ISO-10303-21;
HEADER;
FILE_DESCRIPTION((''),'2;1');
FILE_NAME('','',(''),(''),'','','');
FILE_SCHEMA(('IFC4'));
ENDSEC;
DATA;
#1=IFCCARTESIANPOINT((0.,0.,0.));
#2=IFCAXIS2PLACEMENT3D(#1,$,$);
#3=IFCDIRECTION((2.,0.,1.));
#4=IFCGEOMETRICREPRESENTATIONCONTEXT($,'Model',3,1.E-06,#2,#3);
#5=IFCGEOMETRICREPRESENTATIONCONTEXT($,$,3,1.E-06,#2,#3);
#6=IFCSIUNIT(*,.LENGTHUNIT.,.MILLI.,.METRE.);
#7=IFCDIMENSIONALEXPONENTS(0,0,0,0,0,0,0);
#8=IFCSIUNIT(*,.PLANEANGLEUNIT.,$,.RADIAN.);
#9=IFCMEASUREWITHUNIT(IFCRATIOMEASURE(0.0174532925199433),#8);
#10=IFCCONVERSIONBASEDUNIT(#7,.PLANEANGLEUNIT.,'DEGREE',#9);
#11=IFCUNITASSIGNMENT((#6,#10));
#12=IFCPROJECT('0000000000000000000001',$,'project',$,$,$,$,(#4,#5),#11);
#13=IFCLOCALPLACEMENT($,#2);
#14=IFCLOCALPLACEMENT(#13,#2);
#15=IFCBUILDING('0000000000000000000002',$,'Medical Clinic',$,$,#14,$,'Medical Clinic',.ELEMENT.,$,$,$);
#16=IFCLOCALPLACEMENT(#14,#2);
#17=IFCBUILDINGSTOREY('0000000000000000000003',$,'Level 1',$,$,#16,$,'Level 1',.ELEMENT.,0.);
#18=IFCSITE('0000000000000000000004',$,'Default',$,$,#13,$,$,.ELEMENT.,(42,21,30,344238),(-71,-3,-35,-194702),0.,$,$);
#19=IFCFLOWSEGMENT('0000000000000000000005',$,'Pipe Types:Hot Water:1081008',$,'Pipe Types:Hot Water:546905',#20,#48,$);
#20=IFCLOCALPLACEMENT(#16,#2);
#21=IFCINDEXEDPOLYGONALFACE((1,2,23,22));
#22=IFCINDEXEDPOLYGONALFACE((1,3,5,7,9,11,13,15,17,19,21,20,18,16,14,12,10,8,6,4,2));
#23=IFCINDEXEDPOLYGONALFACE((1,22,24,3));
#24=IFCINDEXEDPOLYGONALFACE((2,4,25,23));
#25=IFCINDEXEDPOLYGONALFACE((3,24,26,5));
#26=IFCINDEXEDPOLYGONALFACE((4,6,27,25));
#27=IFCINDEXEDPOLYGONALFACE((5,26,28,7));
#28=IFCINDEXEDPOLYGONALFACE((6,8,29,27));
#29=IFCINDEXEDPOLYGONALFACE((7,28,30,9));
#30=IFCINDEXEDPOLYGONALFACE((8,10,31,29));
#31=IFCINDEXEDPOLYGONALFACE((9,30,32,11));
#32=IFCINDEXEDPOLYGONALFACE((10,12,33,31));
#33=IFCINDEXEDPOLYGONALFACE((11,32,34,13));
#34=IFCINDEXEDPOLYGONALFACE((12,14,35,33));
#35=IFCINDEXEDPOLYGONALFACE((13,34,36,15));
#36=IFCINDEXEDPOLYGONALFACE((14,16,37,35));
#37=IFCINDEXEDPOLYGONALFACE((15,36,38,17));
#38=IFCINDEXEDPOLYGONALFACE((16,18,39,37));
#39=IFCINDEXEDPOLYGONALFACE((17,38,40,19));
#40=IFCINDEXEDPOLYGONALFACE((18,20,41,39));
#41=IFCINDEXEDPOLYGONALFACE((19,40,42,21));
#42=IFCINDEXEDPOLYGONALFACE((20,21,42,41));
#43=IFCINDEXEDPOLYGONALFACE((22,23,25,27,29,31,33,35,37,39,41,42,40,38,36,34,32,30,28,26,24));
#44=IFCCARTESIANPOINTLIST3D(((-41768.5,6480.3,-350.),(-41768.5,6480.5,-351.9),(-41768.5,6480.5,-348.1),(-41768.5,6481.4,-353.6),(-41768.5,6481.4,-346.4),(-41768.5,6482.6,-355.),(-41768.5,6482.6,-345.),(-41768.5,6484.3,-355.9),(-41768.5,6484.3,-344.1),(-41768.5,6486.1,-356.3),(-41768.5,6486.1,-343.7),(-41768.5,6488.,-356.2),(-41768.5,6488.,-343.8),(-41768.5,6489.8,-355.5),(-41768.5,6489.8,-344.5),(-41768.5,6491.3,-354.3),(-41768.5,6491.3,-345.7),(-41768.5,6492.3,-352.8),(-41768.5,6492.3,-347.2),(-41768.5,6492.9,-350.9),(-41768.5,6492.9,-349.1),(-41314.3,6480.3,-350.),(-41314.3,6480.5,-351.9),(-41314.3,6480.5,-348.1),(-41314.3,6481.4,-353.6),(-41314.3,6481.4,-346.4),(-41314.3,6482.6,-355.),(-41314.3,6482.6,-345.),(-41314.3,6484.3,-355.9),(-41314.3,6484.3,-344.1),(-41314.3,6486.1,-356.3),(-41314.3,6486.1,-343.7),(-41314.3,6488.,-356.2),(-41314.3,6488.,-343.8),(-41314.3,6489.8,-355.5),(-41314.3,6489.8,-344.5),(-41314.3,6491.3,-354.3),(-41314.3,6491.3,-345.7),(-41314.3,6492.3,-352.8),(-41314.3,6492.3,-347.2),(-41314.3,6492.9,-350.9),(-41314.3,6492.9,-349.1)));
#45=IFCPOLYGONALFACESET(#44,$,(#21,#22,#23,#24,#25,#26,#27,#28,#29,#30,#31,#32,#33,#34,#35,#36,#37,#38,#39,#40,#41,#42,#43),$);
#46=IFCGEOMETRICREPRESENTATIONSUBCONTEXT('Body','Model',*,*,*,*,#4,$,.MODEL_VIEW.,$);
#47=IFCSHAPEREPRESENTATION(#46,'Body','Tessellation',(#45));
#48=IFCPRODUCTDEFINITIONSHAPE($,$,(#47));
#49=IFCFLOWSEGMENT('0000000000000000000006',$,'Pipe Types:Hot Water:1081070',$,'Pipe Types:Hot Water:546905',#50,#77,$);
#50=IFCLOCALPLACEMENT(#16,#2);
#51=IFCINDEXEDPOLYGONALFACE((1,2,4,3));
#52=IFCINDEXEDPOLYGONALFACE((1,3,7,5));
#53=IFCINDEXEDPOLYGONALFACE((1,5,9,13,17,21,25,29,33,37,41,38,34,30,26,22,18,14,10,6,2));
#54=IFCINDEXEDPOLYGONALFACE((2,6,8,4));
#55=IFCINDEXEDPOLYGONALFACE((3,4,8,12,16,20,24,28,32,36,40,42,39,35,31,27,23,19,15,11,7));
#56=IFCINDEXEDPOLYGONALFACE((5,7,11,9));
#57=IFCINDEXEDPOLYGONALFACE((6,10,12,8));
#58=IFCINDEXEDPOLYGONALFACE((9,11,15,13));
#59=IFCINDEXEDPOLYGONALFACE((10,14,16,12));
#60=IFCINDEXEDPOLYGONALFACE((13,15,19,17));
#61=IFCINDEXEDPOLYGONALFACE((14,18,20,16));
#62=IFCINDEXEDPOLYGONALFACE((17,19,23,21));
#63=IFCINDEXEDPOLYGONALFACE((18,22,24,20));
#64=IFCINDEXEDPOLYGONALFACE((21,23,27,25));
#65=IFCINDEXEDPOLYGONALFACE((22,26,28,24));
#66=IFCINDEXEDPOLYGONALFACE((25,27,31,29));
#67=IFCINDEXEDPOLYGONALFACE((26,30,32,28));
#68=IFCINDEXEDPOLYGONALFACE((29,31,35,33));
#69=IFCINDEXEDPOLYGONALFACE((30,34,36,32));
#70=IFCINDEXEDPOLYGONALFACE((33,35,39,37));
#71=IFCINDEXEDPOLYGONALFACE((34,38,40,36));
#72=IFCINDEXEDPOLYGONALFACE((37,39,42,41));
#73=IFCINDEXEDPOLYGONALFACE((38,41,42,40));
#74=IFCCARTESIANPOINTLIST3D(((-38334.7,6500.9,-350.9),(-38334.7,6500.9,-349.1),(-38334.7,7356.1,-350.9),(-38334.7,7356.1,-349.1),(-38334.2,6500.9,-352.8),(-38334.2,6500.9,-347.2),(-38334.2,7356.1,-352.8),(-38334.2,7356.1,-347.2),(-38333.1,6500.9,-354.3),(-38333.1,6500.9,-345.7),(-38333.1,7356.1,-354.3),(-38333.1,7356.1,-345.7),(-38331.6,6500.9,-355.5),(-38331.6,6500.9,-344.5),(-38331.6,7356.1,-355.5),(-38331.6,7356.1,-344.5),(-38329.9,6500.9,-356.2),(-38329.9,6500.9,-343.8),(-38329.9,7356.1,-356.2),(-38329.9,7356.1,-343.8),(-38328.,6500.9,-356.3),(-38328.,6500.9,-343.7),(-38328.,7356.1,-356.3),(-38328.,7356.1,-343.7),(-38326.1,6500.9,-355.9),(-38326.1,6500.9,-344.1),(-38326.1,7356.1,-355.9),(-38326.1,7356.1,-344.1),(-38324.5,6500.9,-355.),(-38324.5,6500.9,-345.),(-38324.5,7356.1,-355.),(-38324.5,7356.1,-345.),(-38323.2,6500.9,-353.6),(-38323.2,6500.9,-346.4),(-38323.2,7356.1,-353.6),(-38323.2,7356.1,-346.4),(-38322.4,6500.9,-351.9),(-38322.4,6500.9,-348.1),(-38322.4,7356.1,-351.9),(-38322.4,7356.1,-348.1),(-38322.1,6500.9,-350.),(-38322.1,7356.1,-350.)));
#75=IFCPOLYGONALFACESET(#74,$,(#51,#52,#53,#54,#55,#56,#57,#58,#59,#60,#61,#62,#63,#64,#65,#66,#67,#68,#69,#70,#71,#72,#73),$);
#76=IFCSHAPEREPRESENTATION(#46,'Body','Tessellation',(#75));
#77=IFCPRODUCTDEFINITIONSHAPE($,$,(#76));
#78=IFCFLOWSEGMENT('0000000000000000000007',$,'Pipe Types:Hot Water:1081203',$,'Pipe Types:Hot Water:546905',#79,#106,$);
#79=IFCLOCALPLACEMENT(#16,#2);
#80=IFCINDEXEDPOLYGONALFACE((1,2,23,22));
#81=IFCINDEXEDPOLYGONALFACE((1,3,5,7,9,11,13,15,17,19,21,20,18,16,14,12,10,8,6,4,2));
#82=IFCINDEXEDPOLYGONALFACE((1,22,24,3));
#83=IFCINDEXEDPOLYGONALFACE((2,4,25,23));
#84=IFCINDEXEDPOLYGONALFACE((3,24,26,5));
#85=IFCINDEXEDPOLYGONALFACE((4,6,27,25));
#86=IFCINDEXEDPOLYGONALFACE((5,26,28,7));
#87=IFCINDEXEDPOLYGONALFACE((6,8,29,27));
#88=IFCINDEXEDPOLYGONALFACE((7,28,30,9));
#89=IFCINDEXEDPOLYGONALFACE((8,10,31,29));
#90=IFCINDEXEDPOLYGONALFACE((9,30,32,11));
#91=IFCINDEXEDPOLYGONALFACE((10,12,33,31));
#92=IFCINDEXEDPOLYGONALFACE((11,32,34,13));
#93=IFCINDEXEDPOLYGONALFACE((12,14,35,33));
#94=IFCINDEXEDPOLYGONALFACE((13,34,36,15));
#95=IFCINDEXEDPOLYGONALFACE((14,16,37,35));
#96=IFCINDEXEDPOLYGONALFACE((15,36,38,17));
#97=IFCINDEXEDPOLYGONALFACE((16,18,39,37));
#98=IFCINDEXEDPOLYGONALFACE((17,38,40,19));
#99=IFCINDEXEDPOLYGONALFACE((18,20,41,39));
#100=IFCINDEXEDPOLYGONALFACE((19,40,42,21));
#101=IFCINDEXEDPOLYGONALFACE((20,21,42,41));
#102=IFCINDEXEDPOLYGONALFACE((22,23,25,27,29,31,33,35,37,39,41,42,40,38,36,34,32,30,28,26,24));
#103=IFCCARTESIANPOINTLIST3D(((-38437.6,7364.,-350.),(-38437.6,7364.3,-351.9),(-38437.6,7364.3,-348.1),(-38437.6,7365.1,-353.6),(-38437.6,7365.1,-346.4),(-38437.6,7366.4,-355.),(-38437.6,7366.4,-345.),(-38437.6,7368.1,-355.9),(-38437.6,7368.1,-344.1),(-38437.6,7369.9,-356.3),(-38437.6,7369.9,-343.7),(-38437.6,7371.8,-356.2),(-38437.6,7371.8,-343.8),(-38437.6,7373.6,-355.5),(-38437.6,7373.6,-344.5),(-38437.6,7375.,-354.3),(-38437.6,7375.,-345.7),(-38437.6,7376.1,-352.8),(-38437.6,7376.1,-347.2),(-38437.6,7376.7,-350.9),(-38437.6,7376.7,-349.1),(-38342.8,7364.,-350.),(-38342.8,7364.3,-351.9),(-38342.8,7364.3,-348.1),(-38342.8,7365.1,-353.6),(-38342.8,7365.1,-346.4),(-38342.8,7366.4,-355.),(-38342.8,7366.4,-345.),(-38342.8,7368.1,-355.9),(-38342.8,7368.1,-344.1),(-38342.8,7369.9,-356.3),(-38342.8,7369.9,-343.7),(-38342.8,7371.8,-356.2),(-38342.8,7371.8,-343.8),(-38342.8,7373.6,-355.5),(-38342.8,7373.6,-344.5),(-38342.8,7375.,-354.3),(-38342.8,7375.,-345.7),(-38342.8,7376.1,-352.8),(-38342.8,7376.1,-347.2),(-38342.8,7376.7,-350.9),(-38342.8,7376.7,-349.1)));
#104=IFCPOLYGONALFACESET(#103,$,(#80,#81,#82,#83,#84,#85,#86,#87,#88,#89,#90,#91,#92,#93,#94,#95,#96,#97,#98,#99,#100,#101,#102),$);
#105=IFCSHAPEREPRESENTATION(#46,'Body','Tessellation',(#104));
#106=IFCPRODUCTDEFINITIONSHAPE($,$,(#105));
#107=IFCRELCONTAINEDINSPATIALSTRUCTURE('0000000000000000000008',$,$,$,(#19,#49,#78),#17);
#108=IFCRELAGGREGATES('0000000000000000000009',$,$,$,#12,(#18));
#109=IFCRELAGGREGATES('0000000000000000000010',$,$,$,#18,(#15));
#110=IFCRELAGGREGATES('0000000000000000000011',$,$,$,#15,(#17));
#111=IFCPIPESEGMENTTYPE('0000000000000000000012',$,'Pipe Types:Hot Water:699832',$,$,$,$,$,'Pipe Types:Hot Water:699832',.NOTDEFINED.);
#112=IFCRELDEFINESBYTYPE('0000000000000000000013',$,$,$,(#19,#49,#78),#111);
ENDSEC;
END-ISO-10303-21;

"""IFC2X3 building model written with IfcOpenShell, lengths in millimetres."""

from ifc_helpers import new_model, entity, si_unit, converted_unit, direction, frame, frame_2d, origin, origin_2d_with_axis, place, context, subcontext, project, spatial, circle, extrude, type_object, element, save


model = new_model("IFC2X3")

# Units and contexts
model_context = context("Model", 3, precision=1e-06, world=origin(), true_north=direction((2.0, 0.0, 1.0)))
context_of_model = context(None, 3, precision=1e-06, world=origin(), true_north=direction((2.0, 0.0, 1.0)))
body_context = subcontext(model_context, "Body", "Model", "MODEL_VIEW")
ifc_project = project(units=[si_unit("LENGTHUNIT", "METRE", prefix="MILLI"), converted_unit("PLANEANGLEUNIT", "DEGREE", entity("IfcRatioMeasure", 0.0174532925199433), si_unit("PLANEANGLEUNIT", "RADIAN"), dimensions=[0, 0, 0, 0, 0, 0, 0])], contexts=[model_context, context_of_model])

# Site, building, storey
site_placement = place(None, origin())
site = spatial("IfcSite", under=ifc_project, at=site_placement, Name="Default", CompositionType="ELEMENT", RefLatitude=(42, 21, 30, 344238), RefLongitude=(-71, -3, -35, -194702), RefElevation=0.0)
building_placement = place(site_placement, origin())
building = spatial("IfcBuilding", under=site, at=building_placement, Name="Medical Clinic", LongName="Medical Clinic", CompositionType="ELEMENT")
storey_placement = place(building_placement, origin())
storey = spatial("IfcBuildingStorey", under=building, at=storey_placement, Name="Level 1", LongName="Level 1", CompositionType="ELEMENT", Elevation=0.0)

# Flow segments
pipe_segment_type_1 = type_object("IfcPipeSegmentType", Name="Pipe Types:Hot Water:699832", ElementType="Pipe Types:Hot Water:699832", PredefinedType="NOTDEFINED")
flow_segment_1_placement = place(storey_placement, origin())
element("IfcFlowSegment", 1, at=flow_segment_1_placement, inside=storey, type_object=pipe_segment_type_1, Name="Pipe Types:Hot Water:1081008", ObjectType="Pipe Types:Hot Water:546905", context=body_context, shape_type="SweptSolid", body=[
    extrude(circle(Radius=6.3, at=frame_2d((0.0, 0.0), x_axis=(1.0, 0.0))), frame((-41768.5, 6486.6, -350.0), z_axis=(1.0, 0.0, 0.0), x_axis=(0.0, -1.0, 0.0)), (0.0, 0.0, 1.0), 454.2),
])
flow_segment_2_placement = place(storey_placement, origin())
element("IfcFlowSegment", 2, at=flow_segment_2_placement, inside=storey, type_object=pipe_segment_type_1, Name="Pipe Types:Hot Water:1081070", ObjectType="Pipe Types:Hot Water:546905", context=body_context, shape_type="SweptSolid", body=[
    extrude(circle(Radius=6.3, at=frame_2d((0.0, 0.0), x_axis=(1.0, 0.0))), frame((-38328.5, 6500.9, -350.0), z_axis=(0.0, 1.0, 0.0), x_axis=(1.0, 0.0, 0.0)), (0.0, 0.0, 1.0), 855.2),
])
flow_segment_3_placement = place(storey_placement, origin())
element("IfcFlowSegment", 3, at=flow_segment_3_placement, inside=storey, type_object=pipe_segment_type_1, Name="Pipe Types:Hot Water:1081203", ObjectType="Pipe Types:Hot Water:546905", context=body_context, shape_type="SweptSolid", body=[
    extrude(circle(Radius=6.3, at=origin_2d_with_axis()), frame((-38437.6, 7370.4, -350.0), z_axis=(1.0, 0.0, 0.0), x_axis=(0.0, -1.0, 0.0)), (0.0, 0.0, 1.0), 94.9),
])

save(model, "model.ifc")
